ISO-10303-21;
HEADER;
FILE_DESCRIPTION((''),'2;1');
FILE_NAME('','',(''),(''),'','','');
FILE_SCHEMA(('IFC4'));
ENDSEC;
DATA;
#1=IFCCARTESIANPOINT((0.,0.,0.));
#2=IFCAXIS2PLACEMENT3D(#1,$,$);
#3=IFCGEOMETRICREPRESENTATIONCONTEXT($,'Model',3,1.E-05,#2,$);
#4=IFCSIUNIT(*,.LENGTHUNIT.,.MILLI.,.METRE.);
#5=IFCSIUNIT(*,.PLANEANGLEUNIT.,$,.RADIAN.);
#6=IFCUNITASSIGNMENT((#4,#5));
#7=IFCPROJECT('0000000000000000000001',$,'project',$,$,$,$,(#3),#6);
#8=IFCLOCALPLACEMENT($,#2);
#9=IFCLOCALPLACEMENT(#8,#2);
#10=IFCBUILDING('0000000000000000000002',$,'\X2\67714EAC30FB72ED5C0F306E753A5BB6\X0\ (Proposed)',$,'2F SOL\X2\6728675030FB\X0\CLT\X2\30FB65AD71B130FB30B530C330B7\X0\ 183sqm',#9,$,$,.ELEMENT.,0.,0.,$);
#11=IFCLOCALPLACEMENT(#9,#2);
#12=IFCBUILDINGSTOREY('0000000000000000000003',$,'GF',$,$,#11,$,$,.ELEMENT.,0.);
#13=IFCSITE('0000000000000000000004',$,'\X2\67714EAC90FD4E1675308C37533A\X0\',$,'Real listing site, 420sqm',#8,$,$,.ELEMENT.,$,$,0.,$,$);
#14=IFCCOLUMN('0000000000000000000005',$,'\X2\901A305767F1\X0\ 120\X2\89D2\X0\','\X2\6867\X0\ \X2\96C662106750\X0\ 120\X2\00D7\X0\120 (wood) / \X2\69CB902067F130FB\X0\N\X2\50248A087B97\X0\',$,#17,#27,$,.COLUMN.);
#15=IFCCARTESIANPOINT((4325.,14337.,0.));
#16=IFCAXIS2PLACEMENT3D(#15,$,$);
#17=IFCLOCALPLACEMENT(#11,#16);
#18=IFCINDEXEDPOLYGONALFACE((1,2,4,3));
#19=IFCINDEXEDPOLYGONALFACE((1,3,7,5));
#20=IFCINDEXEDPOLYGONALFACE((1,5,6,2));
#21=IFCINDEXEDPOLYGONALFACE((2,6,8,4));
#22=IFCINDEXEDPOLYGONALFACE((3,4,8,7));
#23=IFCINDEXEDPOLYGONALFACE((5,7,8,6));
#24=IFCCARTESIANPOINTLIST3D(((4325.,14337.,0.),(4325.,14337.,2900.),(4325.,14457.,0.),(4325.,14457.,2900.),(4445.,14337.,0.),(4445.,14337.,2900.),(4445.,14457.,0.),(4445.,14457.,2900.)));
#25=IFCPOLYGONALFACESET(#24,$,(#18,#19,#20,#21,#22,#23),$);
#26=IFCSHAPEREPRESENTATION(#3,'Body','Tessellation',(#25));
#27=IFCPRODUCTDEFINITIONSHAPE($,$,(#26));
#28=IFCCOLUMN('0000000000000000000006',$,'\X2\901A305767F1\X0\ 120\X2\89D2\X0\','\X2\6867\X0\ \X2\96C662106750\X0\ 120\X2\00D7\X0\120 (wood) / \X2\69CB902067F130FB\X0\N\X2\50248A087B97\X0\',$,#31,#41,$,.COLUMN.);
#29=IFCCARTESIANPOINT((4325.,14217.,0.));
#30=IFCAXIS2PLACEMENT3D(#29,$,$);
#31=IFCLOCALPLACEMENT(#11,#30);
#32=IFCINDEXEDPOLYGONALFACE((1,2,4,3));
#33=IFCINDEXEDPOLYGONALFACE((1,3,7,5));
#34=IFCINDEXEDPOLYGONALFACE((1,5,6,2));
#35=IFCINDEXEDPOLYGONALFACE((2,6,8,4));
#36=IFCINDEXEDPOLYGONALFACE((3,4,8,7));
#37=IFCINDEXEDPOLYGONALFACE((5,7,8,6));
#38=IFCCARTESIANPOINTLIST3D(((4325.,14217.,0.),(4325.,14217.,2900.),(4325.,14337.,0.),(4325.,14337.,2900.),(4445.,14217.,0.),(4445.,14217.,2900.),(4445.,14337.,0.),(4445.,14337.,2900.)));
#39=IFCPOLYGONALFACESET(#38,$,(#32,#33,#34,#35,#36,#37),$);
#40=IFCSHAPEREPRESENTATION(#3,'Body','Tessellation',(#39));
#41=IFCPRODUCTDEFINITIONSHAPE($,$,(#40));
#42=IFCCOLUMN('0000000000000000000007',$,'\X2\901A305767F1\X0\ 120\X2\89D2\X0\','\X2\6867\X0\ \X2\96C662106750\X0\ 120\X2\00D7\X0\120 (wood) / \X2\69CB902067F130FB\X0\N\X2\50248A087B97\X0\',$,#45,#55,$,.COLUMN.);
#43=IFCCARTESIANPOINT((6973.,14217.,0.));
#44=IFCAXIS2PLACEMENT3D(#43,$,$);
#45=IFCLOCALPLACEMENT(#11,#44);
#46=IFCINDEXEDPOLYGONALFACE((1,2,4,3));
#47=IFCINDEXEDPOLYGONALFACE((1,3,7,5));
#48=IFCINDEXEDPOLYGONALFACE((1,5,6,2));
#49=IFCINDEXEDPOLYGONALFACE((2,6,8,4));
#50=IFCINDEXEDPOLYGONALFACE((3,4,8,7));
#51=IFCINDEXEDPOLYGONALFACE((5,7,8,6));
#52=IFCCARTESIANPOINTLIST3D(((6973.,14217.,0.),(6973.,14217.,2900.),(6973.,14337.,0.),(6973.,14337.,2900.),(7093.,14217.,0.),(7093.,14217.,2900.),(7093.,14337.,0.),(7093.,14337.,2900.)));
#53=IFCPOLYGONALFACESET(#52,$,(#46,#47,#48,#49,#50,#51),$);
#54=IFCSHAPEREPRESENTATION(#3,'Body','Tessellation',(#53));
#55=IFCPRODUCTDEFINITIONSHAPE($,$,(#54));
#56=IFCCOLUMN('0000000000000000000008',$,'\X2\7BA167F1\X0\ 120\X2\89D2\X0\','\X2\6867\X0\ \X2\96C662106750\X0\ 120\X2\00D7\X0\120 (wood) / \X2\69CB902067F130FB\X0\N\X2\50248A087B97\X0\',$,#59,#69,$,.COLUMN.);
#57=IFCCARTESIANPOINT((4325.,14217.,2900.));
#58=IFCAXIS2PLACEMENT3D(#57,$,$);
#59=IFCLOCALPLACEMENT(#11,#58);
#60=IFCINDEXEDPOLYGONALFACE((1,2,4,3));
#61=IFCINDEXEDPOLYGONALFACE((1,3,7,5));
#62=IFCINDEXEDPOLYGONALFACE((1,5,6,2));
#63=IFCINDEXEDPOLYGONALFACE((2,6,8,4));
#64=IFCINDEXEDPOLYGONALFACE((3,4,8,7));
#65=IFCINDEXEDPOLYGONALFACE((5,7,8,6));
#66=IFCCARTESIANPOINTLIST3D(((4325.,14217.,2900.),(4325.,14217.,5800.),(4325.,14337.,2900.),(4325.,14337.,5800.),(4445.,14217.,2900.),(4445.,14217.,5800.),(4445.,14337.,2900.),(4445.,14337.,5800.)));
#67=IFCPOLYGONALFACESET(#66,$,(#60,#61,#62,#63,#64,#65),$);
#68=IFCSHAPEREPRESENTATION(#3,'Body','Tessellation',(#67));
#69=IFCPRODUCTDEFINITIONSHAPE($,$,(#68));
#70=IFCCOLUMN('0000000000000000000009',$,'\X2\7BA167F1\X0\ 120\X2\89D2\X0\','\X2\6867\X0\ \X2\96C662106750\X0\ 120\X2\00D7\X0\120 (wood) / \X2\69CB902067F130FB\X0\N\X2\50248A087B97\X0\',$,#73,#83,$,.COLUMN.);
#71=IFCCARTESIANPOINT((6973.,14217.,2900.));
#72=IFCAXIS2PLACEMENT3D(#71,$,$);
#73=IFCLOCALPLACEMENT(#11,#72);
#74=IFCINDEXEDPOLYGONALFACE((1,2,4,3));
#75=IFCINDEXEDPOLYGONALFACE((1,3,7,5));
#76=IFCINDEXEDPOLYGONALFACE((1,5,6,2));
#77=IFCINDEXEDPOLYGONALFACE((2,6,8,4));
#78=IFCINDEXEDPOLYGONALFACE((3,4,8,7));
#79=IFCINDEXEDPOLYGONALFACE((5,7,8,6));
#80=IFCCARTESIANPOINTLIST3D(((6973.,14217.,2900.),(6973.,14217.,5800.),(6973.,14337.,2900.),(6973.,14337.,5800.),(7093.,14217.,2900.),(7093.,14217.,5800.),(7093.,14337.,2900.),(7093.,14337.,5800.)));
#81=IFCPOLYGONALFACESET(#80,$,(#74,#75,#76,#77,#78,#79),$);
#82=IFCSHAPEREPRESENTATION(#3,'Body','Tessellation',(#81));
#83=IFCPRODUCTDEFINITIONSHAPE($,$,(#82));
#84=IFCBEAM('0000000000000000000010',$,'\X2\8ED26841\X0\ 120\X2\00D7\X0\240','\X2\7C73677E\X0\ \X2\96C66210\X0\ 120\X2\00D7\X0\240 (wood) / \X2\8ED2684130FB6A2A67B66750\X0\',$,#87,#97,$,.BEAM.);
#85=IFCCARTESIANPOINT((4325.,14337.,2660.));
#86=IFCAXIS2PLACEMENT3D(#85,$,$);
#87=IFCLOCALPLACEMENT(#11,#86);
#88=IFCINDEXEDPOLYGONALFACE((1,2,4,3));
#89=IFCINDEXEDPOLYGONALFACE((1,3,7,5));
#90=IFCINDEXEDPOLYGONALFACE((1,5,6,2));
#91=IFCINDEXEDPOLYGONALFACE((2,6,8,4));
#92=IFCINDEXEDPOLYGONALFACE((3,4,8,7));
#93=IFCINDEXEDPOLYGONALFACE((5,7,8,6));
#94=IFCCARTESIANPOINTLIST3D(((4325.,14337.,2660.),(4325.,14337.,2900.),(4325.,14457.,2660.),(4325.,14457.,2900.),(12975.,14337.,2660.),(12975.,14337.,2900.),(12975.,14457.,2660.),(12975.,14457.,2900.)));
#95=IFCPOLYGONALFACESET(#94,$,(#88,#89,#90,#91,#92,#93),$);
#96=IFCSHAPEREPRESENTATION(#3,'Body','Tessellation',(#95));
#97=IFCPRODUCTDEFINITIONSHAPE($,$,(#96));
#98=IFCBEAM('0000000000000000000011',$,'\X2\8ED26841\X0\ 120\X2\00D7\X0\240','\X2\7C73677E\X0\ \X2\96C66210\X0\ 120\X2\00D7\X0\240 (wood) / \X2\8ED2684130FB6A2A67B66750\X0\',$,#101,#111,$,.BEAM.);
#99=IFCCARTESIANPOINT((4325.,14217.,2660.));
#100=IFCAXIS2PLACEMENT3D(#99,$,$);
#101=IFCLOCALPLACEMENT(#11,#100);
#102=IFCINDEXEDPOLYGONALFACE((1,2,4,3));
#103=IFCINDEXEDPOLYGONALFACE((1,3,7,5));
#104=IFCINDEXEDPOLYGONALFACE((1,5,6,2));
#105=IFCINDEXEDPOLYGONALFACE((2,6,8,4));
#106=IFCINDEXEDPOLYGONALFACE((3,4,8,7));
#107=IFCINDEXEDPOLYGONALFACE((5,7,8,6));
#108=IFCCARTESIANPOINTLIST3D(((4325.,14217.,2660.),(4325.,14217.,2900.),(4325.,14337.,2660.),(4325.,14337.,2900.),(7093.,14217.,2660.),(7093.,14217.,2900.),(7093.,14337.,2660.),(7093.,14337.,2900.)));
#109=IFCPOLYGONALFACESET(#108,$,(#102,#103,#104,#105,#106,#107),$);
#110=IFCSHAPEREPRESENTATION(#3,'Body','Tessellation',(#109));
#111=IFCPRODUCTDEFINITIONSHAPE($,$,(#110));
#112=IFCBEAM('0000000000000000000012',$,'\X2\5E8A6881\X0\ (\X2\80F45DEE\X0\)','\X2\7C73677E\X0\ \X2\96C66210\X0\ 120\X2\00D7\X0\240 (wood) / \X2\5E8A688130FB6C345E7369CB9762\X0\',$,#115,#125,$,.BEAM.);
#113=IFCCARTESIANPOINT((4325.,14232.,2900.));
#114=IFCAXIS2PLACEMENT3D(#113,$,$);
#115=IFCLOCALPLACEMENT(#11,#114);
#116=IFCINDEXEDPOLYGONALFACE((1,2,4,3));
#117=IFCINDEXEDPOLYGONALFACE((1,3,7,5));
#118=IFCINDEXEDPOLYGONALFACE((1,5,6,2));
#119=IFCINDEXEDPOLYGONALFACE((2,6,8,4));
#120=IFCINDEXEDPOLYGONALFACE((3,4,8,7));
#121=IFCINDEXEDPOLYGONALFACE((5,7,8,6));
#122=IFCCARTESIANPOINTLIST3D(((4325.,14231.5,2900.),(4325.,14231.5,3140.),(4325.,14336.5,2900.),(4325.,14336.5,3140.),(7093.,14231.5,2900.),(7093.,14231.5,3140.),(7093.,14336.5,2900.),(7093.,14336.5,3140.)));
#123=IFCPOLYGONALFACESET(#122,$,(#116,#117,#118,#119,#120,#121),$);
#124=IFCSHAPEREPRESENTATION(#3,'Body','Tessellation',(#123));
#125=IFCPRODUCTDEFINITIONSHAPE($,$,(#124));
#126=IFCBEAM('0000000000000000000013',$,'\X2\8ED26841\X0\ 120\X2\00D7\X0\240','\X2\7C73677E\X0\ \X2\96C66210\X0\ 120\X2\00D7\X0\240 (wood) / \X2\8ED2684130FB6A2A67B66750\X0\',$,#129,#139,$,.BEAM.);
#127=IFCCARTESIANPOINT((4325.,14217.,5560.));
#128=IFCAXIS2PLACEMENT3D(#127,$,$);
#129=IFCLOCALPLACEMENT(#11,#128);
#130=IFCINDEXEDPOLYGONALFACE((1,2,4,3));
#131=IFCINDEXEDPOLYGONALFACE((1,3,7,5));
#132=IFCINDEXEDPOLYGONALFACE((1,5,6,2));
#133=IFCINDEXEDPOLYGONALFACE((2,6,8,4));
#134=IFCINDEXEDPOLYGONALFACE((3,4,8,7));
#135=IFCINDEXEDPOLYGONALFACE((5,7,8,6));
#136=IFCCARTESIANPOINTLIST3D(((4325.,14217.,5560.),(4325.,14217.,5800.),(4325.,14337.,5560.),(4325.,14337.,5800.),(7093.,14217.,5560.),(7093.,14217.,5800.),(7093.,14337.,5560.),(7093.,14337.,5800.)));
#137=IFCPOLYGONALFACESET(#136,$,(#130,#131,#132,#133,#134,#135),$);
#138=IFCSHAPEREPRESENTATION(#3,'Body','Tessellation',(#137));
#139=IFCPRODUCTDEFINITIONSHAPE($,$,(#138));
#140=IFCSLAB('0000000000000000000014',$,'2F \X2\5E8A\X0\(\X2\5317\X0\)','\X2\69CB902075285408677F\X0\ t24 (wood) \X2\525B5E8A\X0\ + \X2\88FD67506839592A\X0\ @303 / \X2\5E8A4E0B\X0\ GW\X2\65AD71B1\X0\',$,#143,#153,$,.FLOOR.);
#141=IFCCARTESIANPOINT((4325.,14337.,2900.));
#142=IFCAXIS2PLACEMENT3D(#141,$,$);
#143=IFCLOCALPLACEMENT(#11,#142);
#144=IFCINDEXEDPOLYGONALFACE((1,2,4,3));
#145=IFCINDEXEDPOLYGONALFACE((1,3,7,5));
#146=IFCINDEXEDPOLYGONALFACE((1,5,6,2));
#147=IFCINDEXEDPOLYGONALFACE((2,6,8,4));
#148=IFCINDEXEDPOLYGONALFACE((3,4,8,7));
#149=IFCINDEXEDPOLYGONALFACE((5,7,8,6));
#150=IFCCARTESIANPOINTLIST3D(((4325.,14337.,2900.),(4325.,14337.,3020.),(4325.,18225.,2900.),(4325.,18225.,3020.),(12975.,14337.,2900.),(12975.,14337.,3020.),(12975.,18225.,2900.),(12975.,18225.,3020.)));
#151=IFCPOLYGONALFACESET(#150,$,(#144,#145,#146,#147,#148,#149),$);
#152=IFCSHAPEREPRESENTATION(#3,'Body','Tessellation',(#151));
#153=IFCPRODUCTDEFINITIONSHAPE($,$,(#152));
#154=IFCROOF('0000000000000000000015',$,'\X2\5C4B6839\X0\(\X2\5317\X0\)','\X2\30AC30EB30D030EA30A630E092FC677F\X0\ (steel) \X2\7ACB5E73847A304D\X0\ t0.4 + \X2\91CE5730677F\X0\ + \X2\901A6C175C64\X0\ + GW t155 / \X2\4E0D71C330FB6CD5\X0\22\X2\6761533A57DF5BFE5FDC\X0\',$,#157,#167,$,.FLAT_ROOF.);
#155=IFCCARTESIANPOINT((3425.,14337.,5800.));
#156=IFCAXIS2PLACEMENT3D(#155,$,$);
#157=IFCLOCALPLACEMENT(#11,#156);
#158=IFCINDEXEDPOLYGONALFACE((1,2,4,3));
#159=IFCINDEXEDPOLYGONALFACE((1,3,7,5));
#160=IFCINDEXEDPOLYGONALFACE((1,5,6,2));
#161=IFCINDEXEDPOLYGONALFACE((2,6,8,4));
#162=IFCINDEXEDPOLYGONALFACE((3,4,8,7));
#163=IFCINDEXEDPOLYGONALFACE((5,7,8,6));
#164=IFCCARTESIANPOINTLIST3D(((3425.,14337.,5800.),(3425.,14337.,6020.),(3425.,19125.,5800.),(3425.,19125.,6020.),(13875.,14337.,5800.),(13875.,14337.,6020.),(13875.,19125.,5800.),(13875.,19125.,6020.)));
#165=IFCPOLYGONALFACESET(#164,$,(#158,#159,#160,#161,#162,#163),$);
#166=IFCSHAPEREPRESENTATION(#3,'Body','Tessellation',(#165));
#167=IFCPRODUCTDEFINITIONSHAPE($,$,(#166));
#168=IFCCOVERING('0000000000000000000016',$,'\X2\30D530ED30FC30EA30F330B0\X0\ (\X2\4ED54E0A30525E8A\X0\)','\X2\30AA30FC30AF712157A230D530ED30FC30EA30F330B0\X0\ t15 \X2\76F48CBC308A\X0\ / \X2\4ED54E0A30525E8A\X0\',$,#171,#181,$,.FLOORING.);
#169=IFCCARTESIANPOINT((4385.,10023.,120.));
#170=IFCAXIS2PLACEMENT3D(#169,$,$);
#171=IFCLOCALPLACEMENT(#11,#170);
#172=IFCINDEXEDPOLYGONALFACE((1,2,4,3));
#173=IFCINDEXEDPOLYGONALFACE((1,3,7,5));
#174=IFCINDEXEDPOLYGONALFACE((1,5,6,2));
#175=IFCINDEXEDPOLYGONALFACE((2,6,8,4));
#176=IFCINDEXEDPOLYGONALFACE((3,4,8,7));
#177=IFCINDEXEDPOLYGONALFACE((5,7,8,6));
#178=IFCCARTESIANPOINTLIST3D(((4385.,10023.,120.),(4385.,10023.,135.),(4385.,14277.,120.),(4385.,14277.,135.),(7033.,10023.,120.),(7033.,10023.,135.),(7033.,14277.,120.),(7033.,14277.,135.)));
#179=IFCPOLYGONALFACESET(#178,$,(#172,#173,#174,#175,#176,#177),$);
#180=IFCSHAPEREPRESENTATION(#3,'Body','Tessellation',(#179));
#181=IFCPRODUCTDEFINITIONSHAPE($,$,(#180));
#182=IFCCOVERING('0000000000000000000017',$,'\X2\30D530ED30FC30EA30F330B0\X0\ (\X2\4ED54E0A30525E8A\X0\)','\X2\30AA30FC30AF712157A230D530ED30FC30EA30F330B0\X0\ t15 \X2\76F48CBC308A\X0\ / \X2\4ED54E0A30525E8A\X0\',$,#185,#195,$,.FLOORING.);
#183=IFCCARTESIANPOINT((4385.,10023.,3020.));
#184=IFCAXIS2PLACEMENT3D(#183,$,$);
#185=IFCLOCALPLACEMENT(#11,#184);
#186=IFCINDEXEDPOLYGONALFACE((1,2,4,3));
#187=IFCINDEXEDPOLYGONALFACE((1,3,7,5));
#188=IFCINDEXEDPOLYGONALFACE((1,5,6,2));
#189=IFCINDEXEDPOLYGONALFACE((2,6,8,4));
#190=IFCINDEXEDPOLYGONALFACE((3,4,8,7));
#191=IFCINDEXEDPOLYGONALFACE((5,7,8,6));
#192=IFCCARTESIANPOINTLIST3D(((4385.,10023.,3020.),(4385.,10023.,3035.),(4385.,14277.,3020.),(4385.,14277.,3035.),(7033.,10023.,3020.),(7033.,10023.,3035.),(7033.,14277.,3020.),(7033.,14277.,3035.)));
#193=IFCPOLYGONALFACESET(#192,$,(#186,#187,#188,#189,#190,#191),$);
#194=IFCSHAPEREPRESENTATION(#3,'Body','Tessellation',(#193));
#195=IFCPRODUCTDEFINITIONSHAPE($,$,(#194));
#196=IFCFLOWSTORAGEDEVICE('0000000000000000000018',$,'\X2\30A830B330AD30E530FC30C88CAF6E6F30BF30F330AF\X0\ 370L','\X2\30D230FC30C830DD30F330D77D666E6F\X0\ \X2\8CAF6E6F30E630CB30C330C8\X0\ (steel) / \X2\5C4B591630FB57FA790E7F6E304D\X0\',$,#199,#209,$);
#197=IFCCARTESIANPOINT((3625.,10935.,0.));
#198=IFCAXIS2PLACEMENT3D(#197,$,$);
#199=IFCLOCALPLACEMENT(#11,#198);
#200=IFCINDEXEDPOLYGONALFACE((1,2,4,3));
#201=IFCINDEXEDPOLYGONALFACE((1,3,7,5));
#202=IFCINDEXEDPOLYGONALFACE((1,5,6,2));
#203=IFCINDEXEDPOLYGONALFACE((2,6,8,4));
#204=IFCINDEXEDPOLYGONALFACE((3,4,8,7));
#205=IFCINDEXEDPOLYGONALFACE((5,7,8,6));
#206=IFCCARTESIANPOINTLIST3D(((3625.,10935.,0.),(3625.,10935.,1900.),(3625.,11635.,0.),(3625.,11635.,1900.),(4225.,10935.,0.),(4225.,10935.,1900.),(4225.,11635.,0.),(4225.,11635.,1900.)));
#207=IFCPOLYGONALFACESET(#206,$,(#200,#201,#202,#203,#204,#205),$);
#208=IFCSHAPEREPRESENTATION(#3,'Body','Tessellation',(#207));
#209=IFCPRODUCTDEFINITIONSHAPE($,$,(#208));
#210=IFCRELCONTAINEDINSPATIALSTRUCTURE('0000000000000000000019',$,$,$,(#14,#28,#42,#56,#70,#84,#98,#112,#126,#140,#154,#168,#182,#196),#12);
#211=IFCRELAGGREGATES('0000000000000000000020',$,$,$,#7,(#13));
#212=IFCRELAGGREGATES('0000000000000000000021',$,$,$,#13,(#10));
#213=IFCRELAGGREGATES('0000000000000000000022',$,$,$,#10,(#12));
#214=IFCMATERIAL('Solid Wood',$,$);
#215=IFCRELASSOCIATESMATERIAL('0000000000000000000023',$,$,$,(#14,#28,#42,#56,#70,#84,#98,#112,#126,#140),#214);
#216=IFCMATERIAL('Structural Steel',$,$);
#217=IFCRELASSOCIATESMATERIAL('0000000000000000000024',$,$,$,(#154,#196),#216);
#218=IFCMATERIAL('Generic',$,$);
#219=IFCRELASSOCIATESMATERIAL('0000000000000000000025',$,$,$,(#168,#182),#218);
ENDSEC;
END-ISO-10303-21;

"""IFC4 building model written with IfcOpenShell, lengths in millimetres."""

from ifc_helpers import new_model, si_unit, frame, frame_2d, origin, place, context, project, spatial, rectangle, extrude, material, element, save


model = new_model("IFC4")

# Units and contexts
model_context = context("Model", 3, precision=1e-05, world=origin())
ifc_project = project(units=[si_unit("LENGTHUNIT", "METRE", prefix="MILLI"), si_unit("PLANEANGLEUNIT", "RADIAN")], contexts=[model_context])

# Site, building, storey
site_placement = place(None, origin())
site = spatial("IfcSite", under=ifc_project, at=site_placement, Name="東京都世田谷区", ObjectType="Real listing site, 420sqm", CompositionType="ELEMENT", RefElevation=0.0)
building_placement = place(site_placement, origin())
building = spatial("IfcBuilding", under=site, at=building_placement, Name="東京・狭小の町家 (Proposed)", ObjectType="2F SOL木材・CLT・断熱・サッシ 183sqm", CompositionType="ELEMENT", ElevationOfRefHeight=0.0, ElevationOfTerrain=0.0)
storey_placement = place(building_placement, origin())
storey = spatial("IfcBuildingStorey", under=building, at=storey_placement, Name="GF", CompositionType="ELEMENT", Elevation=0.0)

# Columns
ifc_material_1 = material(Name="Solid Wood")
column_1_placement = place(storey_placement, frame((4325.0, 14337.0, 0.0)))
element("IfcColumn", 1, at=column_1_placement, inside=storey, material=ifc_material_1, Name="通し柱 120角", Description="桧 集成材 120×120 (wood) / 構造柱・N値計算", PredefinedType="COLUMN", context=model_context, shape_type="SweptSolid", body=[
    extrude(rectangle(XDim=120.0, YDim=120.0, at=frame_2d((60.0, 60.0))), frame((4325.0, 14337.0, 0.0)), (0.0, 0.0, 1.0), 2900.0),
])
column_2_placement = place(storey_placement, frame((4325.0, 14217.0, 0.0)))
element("IfcColumn", 2, at=column_2_placement, inside=storey, material=ifc_material_1, Name="通し柱 120角", Description="桧 集成材 120×120 (wood) / 構造柱・N値計算", PredefinedType="COLUMN", context=model_context, shape_type="SweptSolid", body=[
    extrude(rectangle(XDim=120.0, YDim=120.0, at=frame_2d((60.0, 60.0))), frame((4325.0, 14217.0, 0.0)), (0.0, 0.0, 1.0), 2900.0),
])
column_3_placement = place(storey_placement, frame((6973.0, 14217.0, 0.0)))
element("IfcColumn", 3, at=column_3_placement, inside=storey, material=ifc_material_1, Name="通し柱 120角", Description="桧 集成材 120×120 (wood) / 構造柱・N値計算", PredefinedType="COLUMN", context=model_context, shape_type="SweptSolid", body=[
    extrude(rectangle(XDim=120.0, YDim=120.0, at=frame_2d((60.0, 60.0))), frame((6973.0, 14217.0, 0.0)), (0.0, 0.0, 1.0), 2900.0),
])
column_4_placement = place(storey_placement, frame((4325.0, 14217.0, 2900.0)))
element("IfcColumn", 4, at=column_4_placement, inside=storey, material=ifc_material_1, Name="管柱 120角", Description="桧 集成材 120×120 (wood) / 構造柱・N値計算", PredefinedType="COLUMN", context=model_context, shape_type="SweptSolid", body=[
    extrude(rectangle(XDim=120.0, YDim=120.0, at=frame_2d((60.0, 60.0))), frame((4325.0, 14217.0, 2900.0)), (0.0, 0.0, 1.0), 2900.0),
])
column_5_placement = place(storey_placement, frame((6973.0, 14217.0, 2900.0)))
element("IfcColumn", 5, at=column_5_placement, inside=storey, material=ifc_material_1, Name="管柱 120角", Description="桧 集成材 120×120 (wood) / 構造柱・N値計算", PredefinedType="COLUMN", context=model_context, shape_type="SweptSolid", body=[
    extrude(rectangle(XDim=120.0, YDim=120.0, at=frame_2d((60.0, 60.0))), frame((6973.0, 14217.0, 2900.0)), (0.0, 0.0, 1.0), 2900.0),
])

# Beams
beam_1_placement = place(storey_placement, frame((4325.0, 14337.0, 2660.0)))
element("IfcBeam", 6, at=beam_1_placement, inside=storey, material=ifc_material_1, Name="軒桁 120×240", Description="米松 集成 120×240 (wood) / 軒桁・横架材", PredefinedType="BEAM", context=model_context, shape_type="SweptSolid", body=[
    extrude(rectangle(XDim=8650.0, YDim=120.0, at=frame_2d((4325.0, 60.0))), frame((4325.0, 14337.0, 2660.0)), (0.0, 0.0, 1.0), 240.0),
])
beam_2_placement = place(storey_placement, frame((4325.0, 14217.0, 2660.0)))
element("IfcBeam", 7, at=beam_2_placement, inside=storey, material=ifc_material_1, Name="軒桁 120×240", Description="米松 集成 120×240 (wood) / 軒桁・横架材", PredefinedType="BEAM", context=model_context, shape_type="SweptSolid", body=[
    extrude(rectangle(XDim=2768.0, YDim=120.0, at=frame_2d((1384.0, 60.0))), frame((4325.0, 14217.0, 2660.0)), (0.0, 0.0, 1.0), 240.0),
])
beam_3_placement = place(storey_placement, frame((4325.0, 14232.0, 2900.0)))
element("IfcBeam", 8, at=beam_3_placement, inside=storey, material=ifc_material_1, Name="床梁 (胴差)", Description="米松 集成 120×240 (wood) / 床梁・水平構面", PredefinedType="BEAM", context=model_context, shape_type="SweptSolid", body=[
    extrude(rectangle(XDim=2768.0, YDim=105.0, at=frame_2d((1384.0, 52.0))), frame((4325.0, 14232.0, 2900.0)), (0.0, 0.0, 1.0), 240.0),
])
beam_4_placement = place(storey_placement, frame((4325.0, 14217.0, 5560.0)))
element("IfcBeam", 9, at=beam_4_placement, inside=storey, material=ifc_material_1, Name="軒桁 120×240", Description="米松 集成 120×240 (wood) / 軒桁・横架材", PredefinedType="BEAM", context=model_context, shape_type="SweptSolid", body=[
    extrude(rectangle(XDim=2768.0, YDim=120.0, at=frame_2d((1384.0, 60.0))), frame((4325.0, 14217.0, 5560.0)), (0.0, 0.0, 1.0), 240.0),
])

# Slab
slab_1_placement = place(storey_placement, frame((4325.0, 14337.0, 2900.0)))
element("IfcSlab", 10, at=slab_1_placement, inside=storey, material=ifc_material_1, Name="2F 床(北)", Description="構造用合板 t24 (wood) 剛床 + 製材根太 @303 / 床下 GW断熱", PredefinedType="FLOOR", context=model_context, shape_type="SweptSolid", body=[
    extrude(rectangle(XDim=8650.0, YDim=3888.0, at=frame_2d((4325.0, 1944.0))), frame((4325.0, 14337.0, 2900.0)), (0.0, 0.0, 1.0), 120.0),
])

# Roof
ifc_material_2 = material(Name="Structural Steel")
for number, where, name in (
    (11, (3425.0, 14337.0, 5800.0), "屋根(北)"),
):
    element("IfcRoof", number, at=place(storey_placement, frame(where)), inside=storey, material=ifc_material_2, Name=name, Description="ガルバリウム鋼板 (steel) 立平葺き t0.4 + 野地板 + 通気層 + GW t155 / 不燃・法22条区域対応", PredefinedType="FLAT_ROOF", context=model_context, shape_type="SweptSolid", body=[
        extrude(rectangle(XDim=10450.0, YDim=4788.0, at=frame_2d((5225.0, 2394.0))), frame((3425.0, 14337.0, 5800.0)), (0.0, 0.0, 1.0), 220.0),
    ])

# Coverings
ifc_material_3 = material(Name="Generic")
covering_1_placement = place(storey_placement, frame((4385.0, 10023.0, 120.0)))
element("IfcCovering", 12, at=covering_1_placement, inside=storey, material=ifc_material_3, Name="フローリング (仕上げ床)", Description="オーク無垢フローリング t15 直貼り / 仕上げ床", PredefinedType="FLOORING", context=model_context, shape_type="SweptSolid", body=[
    extrude(rectangle(XDim=2648.0, YDim=4254.0, at=frame_2d((1324.0, 2127.0))), frame((4385.0, 10023.0, 120.0)), (0.0, 0.0, 1.0), 15.0),
])
covering_2_placement = place(storey_placement, frame((4385.0, 10023.0, 3020.0)))
element("IfcCovering", 13, at=covering_2_placement, inside=storey, material=ifc_material_3, Name="フローリング (仕上げ床)", Description="オーク無垢フローリング t15 直貼り / 仕上げ床", PredefinedType="FLOORING", context=model_context, shape_type="SweptSolid", body=[
    extrude(rectangle(XDim=2648.0, YDim=4254.0, at=frame_2d((1324.0, 2127.0))), frame((4385.0, 10023.0, 3020.0)), (0.0, 0.0, 1.0), 15.0),
])

# Flow storage device
flow_storage_device_placement = place(storey_placement, frame((3625.0, 10935.0, 0.0)))
element("IfcFlowStorageDevice", 14, at=flow_storage_device_placement, inside=storey, material=ifc_material_2, Name="エコキュート貯湯タンク 370L", Description="ヒートポンプ給湯 貯湯ユニット (steel) / 屋外・基礎置き", context=model_context, shape_type="SweptSolid", body=[
    extrude(rectangle(XDim=600.0, YDim=700.0, at=frame_2d((300.0, 350.0))), frame((3625.0, 10935.0, 0.0)), (0.0, 0.0, 1.0), 1900.0),
])

save(model, "model.ifc")
